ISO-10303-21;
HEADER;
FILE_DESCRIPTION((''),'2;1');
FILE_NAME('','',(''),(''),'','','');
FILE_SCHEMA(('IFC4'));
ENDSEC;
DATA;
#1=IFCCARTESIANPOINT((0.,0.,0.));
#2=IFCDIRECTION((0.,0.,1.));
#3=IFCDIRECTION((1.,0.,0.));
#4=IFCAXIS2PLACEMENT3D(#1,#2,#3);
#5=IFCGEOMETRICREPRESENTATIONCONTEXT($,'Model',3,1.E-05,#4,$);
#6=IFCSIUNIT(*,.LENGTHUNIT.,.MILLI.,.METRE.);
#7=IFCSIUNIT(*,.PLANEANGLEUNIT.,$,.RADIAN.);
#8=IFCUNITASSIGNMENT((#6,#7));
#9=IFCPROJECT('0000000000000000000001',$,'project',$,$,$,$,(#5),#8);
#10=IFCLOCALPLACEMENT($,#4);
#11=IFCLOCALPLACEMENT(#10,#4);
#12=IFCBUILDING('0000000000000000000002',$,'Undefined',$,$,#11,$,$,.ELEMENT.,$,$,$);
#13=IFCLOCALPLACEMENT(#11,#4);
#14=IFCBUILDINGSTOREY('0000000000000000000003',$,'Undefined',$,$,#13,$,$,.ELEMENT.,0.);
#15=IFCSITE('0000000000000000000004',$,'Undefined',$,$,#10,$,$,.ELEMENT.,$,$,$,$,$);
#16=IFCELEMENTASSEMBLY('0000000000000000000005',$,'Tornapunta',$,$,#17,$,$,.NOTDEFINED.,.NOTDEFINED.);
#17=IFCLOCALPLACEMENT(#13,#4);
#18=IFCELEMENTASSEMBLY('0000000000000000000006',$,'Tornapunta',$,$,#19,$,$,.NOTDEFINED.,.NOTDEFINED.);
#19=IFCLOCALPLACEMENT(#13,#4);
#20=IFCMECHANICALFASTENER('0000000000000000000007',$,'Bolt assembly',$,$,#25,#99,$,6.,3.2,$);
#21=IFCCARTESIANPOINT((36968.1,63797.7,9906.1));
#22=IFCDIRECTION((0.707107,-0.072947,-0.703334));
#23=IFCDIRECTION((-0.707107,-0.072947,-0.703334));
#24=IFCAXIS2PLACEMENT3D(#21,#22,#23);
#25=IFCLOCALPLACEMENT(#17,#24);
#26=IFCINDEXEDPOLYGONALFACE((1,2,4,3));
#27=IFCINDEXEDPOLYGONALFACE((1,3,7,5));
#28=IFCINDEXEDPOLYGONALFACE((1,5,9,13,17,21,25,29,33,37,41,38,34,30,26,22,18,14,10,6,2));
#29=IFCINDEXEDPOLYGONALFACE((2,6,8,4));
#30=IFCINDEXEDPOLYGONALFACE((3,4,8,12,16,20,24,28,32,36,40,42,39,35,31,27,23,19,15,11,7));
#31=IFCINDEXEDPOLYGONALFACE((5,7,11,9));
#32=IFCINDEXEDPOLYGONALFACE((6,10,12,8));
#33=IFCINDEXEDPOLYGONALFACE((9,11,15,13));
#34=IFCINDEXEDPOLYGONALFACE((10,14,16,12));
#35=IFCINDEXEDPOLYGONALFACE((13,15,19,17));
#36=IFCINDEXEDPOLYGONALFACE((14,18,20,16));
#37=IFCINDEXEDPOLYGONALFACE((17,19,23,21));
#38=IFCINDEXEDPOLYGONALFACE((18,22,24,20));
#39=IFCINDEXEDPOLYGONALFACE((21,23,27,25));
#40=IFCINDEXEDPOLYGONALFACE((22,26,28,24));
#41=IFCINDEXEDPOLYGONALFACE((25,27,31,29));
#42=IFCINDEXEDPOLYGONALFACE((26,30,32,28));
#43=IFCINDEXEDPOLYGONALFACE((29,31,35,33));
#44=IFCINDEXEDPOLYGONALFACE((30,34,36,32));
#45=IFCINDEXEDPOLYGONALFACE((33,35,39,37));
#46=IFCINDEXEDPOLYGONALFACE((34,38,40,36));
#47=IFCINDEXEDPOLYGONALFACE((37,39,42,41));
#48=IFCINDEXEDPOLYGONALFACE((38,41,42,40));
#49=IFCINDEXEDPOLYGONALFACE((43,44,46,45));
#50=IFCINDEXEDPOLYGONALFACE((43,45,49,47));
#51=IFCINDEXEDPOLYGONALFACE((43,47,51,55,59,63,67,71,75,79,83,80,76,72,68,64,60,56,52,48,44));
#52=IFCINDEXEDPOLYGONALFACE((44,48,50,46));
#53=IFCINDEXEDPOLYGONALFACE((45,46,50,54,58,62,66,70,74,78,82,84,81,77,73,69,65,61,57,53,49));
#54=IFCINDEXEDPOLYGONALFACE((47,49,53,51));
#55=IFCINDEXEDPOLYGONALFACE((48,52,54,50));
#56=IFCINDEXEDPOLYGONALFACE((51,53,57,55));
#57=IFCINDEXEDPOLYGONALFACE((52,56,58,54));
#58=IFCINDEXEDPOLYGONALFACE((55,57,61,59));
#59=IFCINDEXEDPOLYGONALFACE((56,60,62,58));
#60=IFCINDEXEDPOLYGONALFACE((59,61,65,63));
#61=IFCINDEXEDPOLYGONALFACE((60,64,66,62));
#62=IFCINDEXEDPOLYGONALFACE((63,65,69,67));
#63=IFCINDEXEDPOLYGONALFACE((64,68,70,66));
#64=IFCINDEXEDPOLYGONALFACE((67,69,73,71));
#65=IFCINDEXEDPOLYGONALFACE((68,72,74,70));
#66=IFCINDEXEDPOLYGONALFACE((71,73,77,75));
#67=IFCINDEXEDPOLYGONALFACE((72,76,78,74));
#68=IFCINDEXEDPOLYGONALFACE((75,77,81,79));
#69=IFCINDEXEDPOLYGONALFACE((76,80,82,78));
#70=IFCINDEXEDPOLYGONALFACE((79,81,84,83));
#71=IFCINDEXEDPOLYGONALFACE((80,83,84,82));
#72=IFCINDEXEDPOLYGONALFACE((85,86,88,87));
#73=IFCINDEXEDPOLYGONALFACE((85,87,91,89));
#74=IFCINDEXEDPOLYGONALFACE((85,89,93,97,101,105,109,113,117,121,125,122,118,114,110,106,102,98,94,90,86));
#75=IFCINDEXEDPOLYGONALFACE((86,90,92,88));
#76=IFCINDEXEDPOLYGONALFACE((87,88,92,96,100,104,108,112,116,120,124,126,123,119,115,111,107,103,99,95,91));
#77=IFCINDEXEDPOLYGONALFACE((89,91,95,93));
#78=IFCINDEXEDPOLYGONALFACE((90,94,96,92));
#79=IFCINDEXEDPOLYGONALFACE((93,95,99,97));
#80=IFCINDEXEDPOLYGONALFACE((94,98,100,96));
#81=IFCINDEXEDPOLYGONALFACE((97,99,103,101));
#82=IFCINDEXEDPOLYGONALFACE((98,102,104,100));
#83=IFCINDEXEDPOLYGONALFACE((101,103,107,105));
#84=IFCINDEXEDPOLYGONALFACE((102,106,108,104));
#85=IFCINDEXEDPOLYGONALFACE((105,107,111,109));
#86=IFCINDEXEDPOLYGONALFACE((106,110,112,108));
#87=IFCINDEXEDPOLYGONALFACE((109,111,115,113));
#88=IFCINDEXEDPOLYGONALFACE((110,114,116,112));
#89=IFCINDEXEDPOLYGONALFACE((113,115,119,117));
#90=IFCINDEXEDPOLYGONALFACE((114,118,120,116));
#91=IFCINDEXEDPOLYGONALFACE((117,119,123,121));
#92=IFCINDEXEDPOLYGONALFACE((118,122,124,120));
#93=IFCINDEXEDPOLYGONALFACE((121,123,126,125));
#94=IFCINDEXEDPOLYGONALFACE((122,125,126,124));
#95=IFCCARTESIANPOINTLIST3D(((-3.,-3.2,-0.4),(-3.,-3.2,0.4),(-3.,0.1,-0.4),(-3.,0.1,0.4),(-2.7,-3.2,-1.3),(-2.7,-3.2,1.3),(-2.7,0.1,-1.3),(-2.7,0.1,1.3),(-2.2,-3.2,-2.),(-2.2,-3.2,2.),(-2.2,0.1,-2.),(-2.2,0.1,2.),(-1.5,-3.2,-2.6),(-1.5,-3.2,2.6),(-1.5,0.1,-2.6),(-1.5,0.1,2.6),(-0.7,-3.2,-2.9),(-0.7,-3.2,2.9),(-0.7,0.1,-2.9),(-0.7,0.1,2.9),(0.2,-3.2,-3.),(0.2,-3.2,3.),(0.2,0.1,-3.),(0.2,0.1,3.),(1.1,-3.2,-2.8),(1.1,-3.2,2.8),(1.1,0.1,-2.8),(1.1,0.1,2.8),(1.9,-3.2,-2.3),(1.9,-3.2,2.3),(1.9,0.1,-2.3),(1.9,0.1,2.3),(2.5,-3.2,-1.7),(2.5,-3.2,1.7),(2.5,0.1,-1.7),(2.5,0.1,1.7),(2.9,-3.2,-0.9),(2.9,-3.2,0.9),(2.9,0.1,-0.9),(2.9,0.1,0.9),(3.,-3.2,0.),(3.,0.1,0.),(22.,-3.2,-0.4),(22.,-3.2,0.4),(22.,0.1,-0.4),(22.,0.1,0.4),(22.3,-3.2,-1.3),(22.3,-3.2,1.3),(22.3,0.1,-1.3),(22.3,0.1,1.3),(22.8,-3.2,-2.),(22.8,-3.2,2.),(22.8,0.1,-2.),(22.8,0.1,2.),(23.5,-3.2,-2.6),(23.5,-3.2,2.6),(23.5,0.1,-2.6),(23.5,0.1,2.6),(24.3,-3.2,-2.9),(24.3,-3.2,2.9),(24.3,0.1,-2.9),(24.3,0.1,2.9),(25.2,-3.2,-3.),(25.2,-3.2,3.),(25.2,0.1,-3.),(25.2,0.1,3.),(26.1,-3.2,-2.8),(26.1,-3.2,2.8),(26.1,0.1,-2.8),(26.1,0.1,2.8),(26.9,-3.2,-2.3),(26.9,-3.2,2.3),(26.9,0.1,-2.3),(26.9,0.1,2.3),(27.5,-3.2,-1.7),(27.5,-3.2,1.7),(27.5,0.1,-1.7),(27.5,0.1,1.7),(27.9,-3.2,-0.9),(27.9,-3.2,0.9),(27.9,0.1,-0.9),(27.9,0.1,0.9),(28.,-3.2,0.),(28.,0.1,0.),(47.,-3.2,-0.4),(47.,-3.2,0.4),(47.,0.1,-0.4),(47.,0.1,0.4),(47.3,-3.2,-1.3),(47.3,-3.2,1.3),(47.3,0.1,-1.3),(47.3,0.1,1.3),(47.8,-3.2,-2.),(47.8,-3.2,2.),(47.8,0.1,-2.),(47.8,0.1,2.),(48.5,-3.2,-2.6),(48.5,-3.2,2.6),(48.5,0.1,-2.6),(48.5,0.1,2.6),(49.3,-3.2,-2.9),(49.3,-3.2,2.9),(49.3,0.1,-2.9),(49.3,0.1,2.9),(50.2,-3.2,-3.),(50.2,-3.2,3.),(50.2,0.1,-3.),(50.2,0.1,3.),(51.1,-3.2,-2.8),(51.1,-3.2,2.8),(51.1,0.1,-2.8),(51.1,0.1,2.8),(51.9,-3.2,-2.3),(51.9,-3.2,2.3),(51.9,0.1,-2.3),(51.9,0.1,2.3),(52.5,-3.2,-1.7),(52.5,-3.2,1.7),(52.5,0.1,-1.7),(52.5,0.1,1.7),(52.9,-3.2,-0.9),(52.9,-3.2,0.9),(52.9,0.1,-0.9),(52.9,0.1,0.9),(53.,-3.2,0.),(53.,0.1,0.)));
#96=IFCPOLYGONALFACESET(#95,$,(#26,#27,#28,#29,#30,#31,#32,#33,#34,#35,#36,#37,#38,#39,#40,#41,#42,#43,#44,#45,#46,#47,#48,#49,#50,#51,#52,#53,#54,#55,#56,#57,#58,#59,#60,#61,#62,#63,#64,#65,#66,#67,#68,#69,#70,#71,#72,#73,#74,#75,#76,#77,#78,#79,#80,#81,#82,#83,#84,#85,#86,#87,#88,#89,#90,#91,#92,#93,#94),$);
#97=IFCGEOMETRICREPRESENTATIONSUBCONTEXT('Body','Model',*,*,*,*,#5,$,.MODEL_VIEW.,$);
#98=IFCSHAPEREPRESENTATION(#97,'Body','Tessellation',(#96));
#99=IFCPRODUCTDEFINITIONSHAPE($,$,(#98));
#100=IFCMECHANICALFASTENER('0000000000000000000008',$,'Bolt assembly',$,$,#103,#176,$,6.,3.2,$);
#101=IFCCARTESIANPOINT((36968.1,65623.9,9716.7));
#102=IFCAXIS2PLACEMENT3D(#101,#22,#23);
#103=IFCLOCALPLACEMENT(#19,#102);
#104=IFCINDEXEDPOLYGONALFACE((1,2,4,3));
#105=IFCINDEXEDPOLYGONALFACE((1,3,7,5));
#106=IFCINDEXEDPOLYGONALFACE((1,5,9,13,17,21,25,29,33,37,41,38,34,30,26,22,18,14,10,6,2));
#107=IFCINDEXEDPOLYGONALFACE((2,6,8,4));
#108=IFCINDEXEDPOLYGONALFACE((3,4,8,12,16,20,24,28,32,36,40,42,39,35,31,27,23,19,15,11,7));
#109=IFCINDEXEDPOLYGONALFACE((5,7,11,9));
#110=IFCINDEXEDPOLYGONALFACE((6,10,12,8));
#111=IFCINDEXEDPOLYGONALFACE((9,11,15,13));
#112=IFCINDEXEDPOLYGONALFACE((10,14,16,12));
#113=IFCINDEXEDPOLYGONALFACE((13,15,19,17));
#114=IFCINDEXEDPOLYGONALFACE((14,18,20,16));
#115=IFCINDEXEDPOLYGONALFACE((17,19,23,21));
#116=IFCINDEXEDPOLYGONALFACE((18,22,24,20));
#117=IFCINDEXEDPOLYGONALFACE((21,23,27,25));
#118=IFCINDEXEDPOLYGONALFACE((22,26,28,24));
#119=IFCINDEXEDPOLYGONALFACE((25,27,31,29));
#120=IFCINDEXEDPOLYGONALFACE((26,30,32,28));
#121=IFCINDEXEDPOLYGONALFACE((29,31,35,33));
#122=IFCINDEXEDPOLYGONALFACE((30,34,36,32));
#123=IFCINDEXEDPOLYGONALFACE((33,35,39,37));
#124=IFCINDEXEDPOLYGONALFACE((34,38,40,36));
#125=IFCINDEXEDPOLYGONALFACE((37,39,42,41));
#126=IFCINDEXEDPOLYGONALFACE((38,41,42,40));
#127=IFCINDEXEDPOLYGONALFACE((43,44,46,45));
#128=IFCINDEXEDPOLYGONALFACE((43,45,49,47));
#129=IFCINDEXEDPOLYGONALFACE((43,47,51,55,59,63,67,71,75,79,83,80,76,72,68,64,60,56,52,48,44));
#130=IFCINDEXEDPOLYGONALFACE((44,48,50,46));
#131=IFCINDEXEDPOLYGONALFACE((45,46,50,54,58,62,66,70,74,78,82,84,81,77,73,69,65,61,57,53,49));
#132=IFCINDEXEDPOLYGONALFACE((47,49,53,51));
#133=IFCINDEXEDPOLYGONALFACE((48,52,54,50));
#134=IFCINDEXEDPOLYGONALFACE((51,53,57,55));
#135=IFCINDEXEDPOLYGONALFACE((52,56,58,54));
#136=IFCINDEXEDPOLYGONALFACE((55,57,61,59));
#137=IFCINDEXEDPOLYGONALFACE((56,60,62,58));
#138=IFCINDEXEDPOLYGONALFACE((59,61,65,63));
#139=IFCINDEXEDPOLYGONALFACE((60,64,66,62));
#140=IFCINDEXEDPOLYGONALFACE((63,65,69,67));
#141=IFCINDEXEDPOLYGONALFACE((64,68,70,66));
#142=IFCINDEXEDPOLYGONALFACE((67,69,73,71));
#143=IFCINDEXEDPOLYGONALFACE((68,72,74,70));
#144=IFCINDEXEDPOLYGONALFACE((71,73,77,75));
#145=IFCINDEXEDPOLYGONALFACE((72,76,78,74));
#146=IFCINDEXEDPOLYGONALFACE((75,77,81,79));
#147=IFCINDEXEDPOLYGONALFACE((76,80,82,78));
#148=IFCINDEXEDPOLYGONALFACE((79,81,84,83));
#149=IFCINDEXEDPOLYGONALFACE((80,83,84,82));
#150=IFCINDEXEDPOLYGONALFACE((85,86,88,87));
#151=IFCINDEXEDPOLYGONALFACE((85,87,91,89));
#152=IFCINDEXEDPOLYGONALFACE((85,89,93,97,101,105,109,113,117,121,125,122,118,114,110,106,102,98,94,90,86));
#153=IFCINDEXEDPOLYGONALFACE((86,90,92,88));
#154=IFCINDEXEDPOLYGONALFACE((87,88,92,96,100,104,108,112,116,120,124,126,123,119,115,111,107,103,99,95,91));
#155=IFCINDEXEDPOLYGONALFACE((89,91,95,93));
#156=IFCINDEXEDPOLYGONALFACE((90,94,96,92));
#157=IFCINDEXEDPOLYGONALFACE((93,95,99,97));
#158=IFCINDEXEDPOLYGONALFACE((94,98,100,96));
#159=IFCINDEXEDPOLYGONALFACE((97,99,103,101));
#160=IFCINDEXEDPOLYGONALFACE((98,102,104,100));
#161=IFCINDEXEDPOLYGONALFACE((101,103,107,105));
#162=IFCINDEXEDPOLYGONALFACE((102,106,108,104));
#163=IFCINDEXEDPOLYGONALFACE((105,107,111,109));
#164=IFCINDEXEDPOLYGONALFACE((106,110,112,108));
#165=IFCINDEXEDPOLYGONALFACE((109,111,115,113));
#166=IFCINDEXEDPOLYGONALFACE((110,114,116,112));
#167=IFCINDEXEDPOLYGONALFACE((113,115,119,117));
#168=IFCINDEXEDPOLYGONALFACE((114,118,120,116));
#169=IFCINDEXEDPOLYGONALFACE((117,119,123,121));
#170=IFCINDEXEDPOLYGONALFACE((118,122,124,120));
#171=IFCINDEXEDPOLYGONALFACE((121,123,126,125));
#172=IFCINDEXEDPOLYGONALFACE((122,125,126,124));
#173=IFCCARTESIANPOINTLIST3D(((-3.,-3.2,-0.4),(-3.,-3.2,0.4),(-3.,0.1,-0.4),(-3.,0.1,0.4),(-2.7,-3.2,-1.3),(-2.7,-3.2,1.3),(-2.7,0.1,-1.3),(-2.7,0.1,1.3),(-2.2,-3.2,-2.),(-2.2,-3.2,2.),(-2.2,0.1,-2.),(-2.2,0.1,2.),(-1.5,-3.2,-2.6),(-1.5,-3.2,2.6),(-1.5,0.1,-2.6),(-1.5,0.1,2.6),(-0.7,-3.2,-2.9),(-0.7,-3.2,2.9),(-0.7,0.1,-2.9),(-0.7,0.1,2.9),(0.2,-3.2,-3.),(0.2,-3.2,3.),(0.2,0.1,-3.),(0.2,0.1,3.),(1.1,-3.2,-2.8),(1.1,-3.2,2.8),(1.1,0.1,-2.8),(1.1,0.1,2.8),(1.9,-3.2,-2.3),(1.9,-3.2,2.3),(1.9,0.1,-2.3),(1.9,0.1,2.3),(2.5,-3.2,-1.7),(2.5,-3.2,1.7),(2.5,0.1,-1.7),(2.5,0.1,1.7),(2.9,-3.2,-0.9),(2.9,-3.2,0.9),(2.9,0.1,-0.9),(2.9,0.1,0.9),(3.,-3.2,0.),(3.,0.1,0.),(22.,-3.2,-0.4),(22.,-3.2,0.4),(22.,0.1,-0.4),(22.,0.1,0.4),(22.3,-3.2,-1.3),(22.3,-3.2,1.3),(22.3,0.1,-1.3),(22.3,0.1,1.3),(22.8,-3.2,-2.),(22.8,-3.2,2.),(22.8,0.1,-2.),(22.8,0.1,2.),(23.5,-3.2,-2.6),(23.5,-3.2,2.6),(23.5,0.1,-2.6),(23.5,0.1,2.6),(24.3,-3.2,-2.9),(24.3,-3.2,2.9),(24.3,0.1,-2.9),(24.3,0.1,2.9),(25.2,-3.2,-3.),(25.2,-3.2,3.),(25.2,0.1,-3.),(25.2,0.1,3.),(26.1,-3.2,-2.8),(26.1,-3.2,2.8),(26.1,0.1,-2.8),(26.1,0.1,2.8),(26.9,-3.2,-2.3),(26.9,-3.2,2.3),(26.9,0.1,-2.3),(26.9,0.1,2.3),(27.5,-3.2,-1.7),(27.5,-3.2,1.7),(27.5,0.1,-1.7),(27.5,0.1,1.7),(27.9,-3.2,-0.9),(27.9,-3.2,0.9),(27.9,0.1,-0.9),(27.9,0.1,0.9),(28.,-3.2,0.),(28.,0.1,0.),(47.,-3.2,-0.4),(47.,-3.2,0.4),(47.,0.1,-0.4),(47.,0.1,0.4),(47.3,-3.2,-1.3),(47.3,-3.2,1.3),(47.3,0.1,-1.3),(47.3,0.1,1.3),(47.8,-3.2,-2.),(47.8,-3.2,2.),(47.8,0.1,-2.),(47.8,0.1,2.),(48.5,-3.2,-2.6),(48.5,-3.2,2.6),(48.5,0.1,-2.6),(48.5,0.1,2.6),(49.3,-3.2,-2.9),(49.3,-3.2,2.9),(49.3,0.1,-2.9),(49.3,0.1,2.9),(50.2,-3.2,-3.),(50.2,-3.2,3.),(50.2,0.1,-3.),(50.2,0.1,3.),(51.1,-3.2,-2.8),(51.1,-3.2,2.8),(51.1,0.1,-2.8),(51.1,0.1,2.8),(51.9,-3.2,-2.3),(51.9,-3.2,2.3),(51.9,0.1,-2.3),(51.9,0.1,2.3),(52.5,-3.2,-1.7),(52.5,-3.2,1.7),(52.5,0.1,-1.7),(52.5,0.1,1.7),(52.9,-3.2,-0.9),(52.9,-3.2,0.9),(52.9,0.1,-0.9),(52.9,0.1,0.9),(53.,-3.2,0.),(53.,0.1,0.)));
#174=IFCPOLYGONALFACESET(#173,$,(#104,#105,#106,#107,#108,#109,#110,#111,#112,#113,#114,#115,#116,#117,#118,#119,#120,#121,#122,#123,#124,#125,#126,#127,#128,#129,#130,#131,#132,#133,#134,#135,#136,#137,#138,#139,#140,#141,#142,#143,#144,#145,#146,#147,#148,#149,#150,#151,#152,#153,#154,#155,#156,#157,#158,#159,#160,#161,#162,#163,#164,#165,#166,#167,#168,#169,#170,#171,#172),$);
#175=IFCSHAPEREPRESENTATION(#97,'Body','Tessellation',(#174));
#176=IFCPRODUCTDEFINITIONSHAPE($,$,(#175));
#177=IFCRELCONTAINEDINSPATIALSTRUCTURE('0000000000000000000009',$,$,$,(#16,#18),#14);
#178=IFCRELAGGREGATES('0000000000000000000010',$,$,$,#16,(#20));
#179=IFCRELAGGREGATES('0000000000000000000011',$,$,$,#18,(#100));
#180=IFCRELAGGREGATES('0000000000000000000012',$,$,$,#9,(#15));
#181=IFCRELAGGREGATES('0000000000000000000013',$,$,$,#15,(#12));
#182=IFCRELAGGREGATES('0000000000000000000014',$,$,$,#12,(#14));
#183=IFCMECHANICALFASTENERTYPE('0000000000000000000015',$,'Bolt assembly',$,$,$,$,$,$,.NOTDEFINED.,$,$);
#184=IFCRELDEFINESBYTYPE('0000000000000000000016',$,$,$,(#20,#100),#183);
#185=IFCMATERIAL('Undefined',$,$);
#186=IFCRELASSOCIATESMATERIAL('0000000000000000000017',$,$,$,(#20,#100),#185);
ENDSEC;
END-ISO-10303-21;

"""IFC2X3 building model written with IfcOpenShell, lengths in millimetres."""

from ifc_helpers import new_model, si_unit, frame, origin_with_axes, origin_2d_with_axis, place, context, subcontext, project, spatial, circle, extrude, source, transform, mapped, material, type_object, element, aggregate, save


model = new_model("IFC2X3")

# Units and contexts
model_context = context("Model", 3, precision=1e-05, world=origin_with_axes())
body_context = subcontext(model_context, "Body", "Model", "MODEL_VIEW")
ifc_project = project(units=[si_unit("LENGTHUNIT", "METRE", prefix="MILLI"), si_unit("PLANEANGLEUNIT", "RADIAN")], contexts=[model_context])

# Site, building, storey
site_placement = place(None, origin_with_axes())
site = spatial("IfcSite", under=ifc_project, at=site_placement, Name="Undefined", CompositionType="ELEMENT")
building_placement = place(site_placement, origin_with_axes())
building = spatial("IfcBuilding", under=site, at=building_placement, Name="Undefined", CompositionType="ELEMENT")
storey_placement = place(building_placement, origin_with_axes())
storey = spatial("IfcBuildingStorey", under=building, at=storey_placement, Name="Undefined", CompositionType="ELEMENT", Elevation=0.0)

# Element assemblies
assembly_1_placement = place(storey_placement, origin_with_axes())
assembly_1 = element("IfcElementAssembly", 1, at=assembly_1_placement, inside=storey, Name="Tornapunta", AssemblyPlace="NOTDEFINED", PredefinedType="NOTDEFINED")
assembly_2_placement = place(storey_placement, origin_with_axes())
assembly_2 = element("IfcElementAssembly", 2, at=assembly_2_placement, inside=storey, Name="Tornapunta", AssemblyPlace="NOTDEFINED", PredefinedType="NOTDEFINED")

# Shared definitions
ifc_material_1 = material(Name="Undefined")
mechanical_fastener_type = type_object("IfcMechanicalFastenerType", Name="Bolt assembly")
shared_shape_1 = source(origin_with_axes(), body_context, "Body", "SweptSolid", [
    extrude(circle(Radius=3.0, at=origin_2d_with_axis()), frame((0.0, -3.2, 0.0), z_axis=(0.0, 1.0, 0.0), x_axis=(1.0, 0.0, 0.0)), (0.0, 0.0, 1.0), 3.3),
])

# Mechanical fasteners
mechanical_fastener_1_placement = place(assembly_1_placement, frame((36968.1, 63797.7, 9906.1), z_axis=(0.707107, -0.072947, -0.703334), x_axis=(-0.707107, -0.072947, -0.703334)))
mechanical_fastener_1 = element("IfcMechanicalFastener", 3, at=mechanical_fastener_1_placement, type_object=mechanical_fastener_type, material=ifc_material_1, Name="Bolt assembly", NominalDiameter=6.0, NominalLength=3.2, context=body_context, shape_type="MappedRepresentation", body=[
    mapped(shared_shape_1, transform((0.0, 0.0, 0.0))),
    mapped(shared_shape_1, transform((25.0, 0.0, 0.0))),
    mapped(shared_shape_1, transform((50.0, 0.0, 0.0))),
])
mechanical_fastener_2_placement = place(assembly_2_placement, frame((36968.1, 65623.9, 9716.7), z_axis=(0.707107, -0.072947, -0.703334), x_axis=(-0.707107, -0.072947, -0.703334)))
mechanical_fastener_2 = element("IfcMechanicalFastener", 4, at=mechanical_fastener_2_placement, type_object=mechanical_fastener_type, material=ifc_material_1, Name="Bolt assembly", NominalDiameter=6.0, NominalLength=3.2, context=body_context, shape_type="MappedRepresentation", body=[
    mapped(shared_shape_1, transform((0.0, 0.0, 0.0))),
    mapped(shared_shape_1, transform((25.0, 0.0, 0.0))),
    mapped(shared_shape_1, transform((50.0, 0.0, 0.0))),
])
aggregate(assembly_1, [mechanical_fastener_1])
aggregate(assembly_2, [mechanical_fastener_2])

save(model, "model.ifc")
